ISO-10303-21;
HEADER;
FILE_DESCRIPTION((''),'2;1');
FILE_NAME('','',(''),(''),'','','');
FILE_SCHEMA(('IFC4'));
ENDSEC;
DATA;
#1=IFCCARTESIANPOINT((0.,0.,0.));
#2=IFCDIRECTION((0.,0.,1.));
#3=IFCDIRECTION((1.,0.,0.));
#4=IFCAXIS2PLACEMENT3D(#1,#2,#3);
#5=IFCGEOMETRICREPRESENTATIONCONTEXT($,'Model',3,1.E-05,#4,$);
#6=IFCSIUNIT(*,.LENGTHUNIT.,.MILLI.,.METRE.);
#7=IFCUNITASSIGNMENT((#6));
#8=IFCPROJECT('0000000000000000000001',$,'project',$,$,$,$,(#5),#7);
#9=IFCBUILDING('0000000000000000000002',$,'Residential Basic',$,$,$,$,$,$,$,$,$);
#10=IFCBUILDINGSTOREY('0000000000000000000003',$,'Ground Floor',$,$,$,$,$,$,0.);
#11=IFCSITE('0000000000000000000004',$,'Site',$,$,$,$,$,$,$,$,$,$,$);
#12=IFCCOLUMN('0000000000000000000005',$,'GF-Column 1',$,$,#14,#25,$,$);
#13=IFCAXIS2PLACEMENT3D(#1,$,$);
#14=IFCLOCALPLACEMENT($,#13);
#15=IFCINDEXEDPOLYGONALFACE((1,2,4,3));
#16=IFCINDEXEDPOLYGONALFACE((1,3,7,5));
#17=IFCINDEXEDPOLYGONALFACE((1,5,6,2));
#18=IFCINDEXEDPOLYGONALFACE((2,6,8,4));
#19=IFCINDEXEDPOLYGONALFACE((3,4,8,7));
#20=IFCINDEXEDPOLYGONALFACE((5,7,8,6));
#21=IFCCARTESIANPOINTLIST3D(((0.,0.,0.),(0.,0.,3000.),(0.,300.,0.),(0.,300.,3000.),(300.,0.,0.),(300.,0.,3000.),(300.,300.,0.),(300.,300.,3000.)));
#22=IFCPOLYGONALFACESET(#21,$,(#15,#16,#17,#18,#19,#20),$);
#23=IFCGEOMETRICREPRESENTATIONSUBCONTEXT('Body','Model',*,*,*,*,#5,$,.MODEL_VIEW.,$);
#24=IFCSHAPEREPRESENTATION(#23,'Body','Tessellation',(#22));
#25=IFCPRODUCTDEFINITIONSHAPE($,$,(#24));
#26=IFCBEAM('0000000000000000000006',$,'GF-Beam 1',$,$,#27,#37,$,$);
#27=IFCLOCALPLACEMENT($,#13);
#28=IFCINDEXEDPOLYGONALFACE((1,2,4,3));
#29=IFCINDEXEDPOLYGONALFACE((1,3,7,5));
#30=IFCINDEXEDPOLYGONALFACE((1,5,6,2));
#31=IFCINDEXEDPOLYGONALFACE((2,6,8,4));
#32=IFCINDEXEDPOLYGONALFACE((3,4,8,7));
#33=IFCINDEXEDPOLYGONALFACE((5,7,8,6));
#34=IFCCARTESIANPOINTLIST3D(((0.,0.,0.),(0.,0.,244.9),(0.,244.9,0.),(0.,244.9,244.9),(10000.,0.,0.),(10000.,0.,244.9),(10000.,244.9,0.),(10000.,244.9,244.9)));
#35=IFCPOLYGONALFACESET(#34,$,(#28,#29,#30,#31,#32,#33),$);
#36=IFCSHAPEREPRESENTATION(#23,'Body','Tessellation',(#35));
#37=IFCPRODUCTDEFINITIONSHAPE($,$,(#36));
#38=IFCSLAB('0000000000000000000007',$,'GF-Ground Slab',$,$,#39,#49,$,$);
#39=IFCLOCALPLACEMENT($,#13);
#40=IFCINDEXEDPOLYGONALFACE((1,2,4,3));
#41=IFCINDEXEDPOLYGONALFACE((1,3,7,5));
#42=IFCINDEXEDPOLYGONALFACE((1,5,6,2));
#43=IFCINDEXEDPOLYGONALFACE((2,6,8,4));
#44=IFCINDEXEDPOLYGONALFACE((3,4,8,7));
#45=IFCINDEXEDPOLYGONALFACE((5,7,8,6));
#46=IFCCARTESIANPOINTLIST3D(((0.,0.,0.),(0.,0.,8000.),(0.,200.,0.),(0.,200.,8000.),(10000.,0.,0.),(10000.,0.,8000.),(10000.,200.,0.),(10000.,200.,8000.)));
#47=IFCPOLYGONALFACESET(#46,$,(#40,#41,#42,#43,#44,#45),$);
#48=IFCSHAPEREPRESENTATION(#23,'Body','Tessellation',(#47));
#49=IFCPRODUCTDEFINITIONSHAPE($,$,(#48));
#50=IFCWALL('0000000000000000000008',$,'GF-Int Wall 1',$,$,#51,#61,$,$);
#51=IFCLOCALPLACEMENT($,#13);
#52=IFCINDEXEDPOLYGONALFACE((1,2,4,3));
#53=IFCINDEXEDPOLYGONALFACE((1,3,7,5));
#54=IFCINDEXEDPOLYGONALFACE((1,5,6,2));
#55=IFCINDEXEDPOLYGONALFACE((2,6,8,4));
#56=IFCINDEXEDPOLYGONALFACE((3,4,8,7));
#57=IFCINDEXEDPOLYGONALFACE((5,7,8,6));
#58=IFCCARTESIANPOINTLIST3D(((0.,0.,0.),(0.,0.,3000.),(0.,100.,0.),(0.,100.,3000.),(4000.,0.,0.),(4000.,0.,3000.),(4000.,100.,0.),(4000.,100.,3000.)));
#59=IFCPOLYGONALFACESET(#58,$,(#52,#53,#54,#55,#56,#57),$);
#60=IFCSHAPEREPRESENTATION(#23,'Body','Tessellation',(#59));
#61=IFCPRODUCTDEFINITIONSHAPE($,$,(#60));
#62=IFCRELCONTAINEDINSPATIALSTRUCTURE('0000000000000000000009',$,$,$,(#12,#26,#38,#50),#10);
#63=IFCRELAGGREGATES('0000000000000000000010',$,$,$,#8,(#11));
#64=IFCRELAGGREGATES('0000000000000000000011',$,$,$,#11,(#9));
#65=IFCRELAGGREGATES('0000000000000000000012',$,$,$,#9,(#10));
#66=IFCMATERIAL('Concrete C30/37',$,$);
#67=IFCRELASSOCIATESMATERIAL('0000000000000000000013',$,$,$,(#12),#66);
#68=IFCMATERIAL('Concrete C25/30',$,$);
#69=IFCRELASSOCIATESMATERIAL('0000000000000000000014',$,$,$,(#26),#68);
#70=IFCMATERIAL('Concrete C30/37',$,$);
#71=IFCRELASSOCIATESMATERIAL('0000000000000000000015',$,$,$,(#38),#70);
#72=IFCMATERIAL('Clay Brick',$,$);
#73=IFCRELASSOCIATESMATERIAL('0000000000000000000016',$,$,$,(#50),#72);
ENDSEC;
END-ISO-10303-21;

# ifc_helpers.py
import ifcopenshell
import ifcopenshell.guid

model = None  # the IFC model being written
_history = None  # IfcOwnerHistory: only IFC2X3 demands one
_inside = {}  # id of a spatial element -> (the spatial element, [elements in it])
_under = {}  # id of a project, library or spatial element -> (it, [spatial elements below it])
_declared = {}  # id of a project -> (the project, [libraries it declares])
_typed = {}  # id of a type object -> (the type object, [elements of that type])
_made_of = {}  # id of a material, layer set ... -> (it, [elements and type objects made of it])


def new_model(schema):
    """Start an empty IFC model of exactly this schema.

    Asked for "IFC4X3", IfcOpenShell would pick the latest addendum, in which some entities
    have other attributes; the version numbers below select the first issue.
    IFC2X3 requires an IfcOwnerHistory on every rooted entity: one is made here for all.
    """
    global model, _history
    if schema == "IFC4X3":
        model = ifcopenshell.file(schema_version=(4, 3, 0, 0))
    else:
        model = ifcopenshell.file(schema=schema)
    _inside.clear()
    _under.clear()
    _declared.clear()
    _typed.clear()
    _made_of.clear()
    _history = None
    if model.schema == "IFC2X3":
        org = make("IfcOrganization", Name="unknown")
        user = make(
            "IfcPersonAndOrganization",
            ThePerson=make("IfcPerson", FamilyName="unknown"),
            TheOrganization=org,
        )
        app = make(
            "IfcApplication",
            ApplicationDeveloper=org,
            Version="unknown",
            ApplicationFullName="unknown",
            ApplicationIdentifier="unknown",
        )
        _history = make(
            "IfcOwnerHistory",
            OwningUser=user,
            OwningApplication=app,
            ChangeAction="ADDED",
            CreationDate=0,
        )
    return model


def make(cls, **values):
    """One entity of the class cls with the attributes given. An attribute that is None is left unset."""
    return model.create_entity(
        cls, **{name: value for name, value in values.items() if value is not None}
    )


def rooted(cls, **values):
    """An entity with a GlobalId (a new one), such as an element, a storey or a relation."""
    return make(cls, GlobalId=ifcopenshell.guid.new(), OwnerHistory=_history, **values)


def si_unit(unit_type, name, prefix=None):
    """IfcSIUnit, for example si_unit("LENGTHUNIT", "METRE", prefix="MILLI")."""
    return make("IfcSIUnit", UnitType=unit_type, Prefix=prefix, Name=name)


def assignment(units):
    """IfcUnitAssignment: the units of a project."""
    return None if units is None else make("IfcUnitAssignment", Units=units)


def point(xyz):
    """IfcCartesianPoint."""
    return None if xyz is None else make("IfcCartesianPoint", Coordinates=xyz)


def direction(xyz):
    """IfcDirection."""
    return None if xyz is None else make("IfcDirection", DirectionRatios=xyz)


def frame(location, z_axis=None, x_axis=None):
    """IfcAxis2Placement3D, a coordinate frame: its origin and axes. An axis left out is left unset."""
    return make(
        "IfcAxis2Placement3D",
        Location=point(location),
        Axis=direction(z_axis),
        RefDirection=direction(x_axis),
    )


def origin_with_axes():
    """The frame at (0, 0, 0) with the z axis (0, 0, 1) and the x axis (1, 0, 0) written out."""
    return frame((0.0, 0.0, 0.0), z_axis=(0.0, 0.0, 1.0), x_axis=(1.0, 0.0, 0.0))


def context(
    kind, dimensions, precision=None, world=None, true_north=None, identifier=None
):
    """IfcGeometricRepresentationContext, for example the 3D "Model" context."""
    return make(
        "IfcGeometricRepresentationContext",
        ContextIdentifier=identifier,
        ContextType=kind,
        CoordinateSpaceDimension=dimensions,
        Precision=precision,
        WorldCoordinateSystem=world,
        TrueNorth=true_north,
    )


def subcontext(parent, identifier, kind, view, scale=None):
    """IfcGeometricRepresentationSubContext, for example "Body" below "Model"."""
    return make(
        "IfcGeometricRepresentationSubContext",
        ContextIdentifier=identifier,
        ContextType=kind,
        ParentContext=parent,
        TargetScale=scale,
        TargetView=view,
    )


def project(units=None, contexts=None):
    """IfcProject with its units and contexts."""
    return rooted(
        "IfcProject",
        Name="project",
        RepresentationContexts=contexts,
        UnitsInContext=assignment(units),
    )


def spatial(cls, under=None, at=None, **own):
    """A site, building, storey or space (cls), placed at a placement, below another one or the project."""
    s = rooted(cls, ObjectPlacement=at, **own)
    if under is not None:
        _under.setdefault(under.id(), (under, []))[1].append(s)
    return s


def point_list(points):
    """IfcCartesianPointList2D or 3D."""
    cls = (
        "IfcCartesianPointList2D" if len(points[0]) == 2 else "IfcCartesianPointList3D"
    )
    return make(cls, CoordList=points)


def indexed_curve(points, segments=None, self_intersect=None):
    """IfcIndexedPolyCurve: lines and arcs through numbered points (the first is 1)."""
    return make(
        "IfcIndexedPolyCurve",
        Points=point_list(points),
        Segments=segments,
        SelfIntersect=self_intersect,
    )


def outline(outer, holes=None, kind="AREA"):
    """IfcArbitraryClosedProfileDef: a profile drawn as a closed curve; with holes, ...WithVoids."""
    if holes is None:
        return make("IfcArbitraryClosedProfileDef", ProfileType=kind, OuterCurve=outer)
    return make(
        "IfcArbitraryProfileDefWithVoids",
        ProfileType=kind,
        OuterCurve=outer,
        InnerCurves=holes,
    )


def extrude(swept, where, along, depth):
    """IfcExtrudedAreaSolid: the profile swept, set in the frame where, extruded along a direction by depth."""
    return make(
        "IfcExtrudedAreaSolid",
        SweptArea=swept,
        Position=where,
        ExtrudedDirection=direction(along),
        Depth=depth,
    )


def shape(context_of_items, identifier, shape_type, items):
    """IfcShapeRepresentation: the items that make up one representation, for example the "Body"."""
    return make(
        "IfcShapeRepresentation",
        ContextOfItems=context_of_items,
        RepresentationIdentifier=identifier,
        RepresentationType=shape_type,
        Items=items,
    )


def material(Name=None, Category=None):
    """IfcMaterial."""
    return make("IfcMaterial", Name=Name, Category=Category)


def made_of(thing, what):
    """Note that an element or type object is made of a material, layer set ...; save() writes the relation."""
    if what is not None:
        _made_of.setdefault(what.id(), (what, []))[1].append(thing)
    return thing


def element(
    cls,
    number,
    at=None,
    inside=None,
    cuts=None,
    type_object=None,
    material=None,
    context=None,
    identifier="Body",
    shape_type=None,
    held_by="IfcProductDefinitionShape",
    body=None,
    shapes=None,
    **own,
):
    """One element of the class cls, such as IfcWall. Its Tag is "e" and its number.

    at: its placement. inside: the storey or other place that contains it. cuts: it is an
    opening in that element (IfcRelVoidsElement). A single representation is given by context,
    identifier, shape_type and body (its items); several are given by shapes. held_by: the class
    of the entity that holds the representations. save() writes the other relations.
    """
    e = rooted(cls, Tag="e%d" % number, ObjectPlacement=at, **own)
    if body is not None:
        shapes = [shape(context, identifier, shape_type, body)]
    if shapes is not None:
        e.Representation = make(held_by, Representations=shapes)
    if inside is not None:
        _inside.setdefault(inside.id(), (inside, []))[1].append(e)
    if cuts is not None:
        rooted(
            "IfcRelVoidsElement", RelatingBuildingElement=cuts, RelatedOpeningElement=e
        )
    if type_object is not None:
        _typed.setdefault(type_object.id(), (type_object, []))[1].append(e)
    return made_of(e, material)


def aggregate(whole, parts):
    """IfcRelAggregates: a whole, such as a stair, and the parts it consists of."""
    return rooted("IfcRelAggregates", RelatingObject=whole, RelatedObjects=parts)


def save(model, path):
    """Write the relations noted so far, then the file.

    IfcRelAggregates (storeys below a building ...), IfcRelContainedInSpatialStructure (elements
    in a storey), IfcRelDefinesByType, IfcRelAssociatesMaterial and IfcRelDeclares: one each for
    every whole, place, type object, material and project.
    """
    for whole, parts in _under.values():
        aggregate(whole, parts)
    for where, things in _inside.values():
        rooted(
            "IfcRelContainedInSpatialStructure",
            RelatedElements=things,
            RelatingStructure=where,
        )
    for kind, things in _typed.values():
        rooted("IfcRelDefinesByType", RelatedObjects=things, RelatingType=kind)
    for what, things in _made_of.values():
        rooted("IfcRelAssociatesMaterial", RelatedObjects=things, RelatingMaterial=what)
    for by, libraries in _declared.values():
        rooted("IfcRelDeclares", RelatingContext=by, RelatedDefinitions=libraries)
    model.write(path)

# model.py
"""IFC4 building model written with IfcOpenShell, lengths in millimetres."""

from ifc_helpers import new_model, si_unit, origin_with_axes, context, subcontext, project, spatial, indexed_curve, outline, extrude, material, element, save


model = new_model("IFC4")

# Units and contexts
model_context = context("Model", 3, precision=1e-05, world=origin_with_axes())
body_context = subcontext(model_context, "Body", "Model", "MODEL_VIEW")
ifc_project = project(units=[si_unit("LENGTHUNIT", "METRE", prefix="MILLI")], contexts=[model_context])

# Site, building, storey
site = spatial("IfcSite", under=ifc_project, Name="Site")
building = spatial("IfcBuilding", under=site, Name="Residential Basic")
storey = spatial("IfcBuildingStorey", under=building, Name="Ground Floor", Elevation=0.0)

# Column
ifc_material_1 = material(Name="Concrete C30/37")
element("IfcColumn", 1, inside=storey, material=ifc_material_1, Name="GF-Column 1", context=body_context, shape_type="SweptSolid", body=[
    extrude(outline(indexed_curve([(0.0, 0.0), (0.0, 300.0), (300.0, 300.0), (300.0, 0.0), (0.0, 0.0)], self_intersect=False)), origin_with_axes(), (0.0, 0.0, 1.0), 3000.0),
])

# Beam
ifc_material_2 = material(Name="Concrete C25/30")
element("IfcBeam", 2, inside=storey, material=ifc_material_2, Name="GF-Beam 1", context=body_context, shape_type="SweptSolid", body=[
    extrude(outline(indexed_curve([(0.0, 0.0), (0.0, 244.9), (10000.0, 244.9), (10000.0, 0.0), (0.0, 0.0)], self_intersect=False)), origin_with_axes(), (0.0, 0.0, 1.0), 244.9),
])

# Slab
ifc_material_3 = material(Name="Concrete C30/37")
element("IfcSlab", 3, inside=storey, material=ifc_material_3, Name="GF-Ground Slab", context=body_context, shape_type="SweptSolid", body=[
    extrude(outline(indexed_curve([(0.0, 0.0), (0.0, 200.0), (10000.0, 200.0), (10000.0, 0.0), (0.0, 0.0)], self_intersect=False)), origin_with_axes(), (0.0, 0.0, 1.0), 8000.0),
])

# Wall
ifc_material_4 = material(Name="Clay Brick")
element("IfcWall", 4, inside=storey, material=ifc_material_4, Name="GF-Int Wall 1", context=body_context, shape_type="SweptSolid", body=[
    extrude(outline(indexed_curve([(0.0, 0.0), (0.0, 100.0), (4000.0, 100.0), (4000.0, 0.0), (0.0, 0.0)], self_intersect=False)), origin_with_axes(), (0.0, 0.0, 1.0), 3000.0),
])

save(model, "model.ifc")
